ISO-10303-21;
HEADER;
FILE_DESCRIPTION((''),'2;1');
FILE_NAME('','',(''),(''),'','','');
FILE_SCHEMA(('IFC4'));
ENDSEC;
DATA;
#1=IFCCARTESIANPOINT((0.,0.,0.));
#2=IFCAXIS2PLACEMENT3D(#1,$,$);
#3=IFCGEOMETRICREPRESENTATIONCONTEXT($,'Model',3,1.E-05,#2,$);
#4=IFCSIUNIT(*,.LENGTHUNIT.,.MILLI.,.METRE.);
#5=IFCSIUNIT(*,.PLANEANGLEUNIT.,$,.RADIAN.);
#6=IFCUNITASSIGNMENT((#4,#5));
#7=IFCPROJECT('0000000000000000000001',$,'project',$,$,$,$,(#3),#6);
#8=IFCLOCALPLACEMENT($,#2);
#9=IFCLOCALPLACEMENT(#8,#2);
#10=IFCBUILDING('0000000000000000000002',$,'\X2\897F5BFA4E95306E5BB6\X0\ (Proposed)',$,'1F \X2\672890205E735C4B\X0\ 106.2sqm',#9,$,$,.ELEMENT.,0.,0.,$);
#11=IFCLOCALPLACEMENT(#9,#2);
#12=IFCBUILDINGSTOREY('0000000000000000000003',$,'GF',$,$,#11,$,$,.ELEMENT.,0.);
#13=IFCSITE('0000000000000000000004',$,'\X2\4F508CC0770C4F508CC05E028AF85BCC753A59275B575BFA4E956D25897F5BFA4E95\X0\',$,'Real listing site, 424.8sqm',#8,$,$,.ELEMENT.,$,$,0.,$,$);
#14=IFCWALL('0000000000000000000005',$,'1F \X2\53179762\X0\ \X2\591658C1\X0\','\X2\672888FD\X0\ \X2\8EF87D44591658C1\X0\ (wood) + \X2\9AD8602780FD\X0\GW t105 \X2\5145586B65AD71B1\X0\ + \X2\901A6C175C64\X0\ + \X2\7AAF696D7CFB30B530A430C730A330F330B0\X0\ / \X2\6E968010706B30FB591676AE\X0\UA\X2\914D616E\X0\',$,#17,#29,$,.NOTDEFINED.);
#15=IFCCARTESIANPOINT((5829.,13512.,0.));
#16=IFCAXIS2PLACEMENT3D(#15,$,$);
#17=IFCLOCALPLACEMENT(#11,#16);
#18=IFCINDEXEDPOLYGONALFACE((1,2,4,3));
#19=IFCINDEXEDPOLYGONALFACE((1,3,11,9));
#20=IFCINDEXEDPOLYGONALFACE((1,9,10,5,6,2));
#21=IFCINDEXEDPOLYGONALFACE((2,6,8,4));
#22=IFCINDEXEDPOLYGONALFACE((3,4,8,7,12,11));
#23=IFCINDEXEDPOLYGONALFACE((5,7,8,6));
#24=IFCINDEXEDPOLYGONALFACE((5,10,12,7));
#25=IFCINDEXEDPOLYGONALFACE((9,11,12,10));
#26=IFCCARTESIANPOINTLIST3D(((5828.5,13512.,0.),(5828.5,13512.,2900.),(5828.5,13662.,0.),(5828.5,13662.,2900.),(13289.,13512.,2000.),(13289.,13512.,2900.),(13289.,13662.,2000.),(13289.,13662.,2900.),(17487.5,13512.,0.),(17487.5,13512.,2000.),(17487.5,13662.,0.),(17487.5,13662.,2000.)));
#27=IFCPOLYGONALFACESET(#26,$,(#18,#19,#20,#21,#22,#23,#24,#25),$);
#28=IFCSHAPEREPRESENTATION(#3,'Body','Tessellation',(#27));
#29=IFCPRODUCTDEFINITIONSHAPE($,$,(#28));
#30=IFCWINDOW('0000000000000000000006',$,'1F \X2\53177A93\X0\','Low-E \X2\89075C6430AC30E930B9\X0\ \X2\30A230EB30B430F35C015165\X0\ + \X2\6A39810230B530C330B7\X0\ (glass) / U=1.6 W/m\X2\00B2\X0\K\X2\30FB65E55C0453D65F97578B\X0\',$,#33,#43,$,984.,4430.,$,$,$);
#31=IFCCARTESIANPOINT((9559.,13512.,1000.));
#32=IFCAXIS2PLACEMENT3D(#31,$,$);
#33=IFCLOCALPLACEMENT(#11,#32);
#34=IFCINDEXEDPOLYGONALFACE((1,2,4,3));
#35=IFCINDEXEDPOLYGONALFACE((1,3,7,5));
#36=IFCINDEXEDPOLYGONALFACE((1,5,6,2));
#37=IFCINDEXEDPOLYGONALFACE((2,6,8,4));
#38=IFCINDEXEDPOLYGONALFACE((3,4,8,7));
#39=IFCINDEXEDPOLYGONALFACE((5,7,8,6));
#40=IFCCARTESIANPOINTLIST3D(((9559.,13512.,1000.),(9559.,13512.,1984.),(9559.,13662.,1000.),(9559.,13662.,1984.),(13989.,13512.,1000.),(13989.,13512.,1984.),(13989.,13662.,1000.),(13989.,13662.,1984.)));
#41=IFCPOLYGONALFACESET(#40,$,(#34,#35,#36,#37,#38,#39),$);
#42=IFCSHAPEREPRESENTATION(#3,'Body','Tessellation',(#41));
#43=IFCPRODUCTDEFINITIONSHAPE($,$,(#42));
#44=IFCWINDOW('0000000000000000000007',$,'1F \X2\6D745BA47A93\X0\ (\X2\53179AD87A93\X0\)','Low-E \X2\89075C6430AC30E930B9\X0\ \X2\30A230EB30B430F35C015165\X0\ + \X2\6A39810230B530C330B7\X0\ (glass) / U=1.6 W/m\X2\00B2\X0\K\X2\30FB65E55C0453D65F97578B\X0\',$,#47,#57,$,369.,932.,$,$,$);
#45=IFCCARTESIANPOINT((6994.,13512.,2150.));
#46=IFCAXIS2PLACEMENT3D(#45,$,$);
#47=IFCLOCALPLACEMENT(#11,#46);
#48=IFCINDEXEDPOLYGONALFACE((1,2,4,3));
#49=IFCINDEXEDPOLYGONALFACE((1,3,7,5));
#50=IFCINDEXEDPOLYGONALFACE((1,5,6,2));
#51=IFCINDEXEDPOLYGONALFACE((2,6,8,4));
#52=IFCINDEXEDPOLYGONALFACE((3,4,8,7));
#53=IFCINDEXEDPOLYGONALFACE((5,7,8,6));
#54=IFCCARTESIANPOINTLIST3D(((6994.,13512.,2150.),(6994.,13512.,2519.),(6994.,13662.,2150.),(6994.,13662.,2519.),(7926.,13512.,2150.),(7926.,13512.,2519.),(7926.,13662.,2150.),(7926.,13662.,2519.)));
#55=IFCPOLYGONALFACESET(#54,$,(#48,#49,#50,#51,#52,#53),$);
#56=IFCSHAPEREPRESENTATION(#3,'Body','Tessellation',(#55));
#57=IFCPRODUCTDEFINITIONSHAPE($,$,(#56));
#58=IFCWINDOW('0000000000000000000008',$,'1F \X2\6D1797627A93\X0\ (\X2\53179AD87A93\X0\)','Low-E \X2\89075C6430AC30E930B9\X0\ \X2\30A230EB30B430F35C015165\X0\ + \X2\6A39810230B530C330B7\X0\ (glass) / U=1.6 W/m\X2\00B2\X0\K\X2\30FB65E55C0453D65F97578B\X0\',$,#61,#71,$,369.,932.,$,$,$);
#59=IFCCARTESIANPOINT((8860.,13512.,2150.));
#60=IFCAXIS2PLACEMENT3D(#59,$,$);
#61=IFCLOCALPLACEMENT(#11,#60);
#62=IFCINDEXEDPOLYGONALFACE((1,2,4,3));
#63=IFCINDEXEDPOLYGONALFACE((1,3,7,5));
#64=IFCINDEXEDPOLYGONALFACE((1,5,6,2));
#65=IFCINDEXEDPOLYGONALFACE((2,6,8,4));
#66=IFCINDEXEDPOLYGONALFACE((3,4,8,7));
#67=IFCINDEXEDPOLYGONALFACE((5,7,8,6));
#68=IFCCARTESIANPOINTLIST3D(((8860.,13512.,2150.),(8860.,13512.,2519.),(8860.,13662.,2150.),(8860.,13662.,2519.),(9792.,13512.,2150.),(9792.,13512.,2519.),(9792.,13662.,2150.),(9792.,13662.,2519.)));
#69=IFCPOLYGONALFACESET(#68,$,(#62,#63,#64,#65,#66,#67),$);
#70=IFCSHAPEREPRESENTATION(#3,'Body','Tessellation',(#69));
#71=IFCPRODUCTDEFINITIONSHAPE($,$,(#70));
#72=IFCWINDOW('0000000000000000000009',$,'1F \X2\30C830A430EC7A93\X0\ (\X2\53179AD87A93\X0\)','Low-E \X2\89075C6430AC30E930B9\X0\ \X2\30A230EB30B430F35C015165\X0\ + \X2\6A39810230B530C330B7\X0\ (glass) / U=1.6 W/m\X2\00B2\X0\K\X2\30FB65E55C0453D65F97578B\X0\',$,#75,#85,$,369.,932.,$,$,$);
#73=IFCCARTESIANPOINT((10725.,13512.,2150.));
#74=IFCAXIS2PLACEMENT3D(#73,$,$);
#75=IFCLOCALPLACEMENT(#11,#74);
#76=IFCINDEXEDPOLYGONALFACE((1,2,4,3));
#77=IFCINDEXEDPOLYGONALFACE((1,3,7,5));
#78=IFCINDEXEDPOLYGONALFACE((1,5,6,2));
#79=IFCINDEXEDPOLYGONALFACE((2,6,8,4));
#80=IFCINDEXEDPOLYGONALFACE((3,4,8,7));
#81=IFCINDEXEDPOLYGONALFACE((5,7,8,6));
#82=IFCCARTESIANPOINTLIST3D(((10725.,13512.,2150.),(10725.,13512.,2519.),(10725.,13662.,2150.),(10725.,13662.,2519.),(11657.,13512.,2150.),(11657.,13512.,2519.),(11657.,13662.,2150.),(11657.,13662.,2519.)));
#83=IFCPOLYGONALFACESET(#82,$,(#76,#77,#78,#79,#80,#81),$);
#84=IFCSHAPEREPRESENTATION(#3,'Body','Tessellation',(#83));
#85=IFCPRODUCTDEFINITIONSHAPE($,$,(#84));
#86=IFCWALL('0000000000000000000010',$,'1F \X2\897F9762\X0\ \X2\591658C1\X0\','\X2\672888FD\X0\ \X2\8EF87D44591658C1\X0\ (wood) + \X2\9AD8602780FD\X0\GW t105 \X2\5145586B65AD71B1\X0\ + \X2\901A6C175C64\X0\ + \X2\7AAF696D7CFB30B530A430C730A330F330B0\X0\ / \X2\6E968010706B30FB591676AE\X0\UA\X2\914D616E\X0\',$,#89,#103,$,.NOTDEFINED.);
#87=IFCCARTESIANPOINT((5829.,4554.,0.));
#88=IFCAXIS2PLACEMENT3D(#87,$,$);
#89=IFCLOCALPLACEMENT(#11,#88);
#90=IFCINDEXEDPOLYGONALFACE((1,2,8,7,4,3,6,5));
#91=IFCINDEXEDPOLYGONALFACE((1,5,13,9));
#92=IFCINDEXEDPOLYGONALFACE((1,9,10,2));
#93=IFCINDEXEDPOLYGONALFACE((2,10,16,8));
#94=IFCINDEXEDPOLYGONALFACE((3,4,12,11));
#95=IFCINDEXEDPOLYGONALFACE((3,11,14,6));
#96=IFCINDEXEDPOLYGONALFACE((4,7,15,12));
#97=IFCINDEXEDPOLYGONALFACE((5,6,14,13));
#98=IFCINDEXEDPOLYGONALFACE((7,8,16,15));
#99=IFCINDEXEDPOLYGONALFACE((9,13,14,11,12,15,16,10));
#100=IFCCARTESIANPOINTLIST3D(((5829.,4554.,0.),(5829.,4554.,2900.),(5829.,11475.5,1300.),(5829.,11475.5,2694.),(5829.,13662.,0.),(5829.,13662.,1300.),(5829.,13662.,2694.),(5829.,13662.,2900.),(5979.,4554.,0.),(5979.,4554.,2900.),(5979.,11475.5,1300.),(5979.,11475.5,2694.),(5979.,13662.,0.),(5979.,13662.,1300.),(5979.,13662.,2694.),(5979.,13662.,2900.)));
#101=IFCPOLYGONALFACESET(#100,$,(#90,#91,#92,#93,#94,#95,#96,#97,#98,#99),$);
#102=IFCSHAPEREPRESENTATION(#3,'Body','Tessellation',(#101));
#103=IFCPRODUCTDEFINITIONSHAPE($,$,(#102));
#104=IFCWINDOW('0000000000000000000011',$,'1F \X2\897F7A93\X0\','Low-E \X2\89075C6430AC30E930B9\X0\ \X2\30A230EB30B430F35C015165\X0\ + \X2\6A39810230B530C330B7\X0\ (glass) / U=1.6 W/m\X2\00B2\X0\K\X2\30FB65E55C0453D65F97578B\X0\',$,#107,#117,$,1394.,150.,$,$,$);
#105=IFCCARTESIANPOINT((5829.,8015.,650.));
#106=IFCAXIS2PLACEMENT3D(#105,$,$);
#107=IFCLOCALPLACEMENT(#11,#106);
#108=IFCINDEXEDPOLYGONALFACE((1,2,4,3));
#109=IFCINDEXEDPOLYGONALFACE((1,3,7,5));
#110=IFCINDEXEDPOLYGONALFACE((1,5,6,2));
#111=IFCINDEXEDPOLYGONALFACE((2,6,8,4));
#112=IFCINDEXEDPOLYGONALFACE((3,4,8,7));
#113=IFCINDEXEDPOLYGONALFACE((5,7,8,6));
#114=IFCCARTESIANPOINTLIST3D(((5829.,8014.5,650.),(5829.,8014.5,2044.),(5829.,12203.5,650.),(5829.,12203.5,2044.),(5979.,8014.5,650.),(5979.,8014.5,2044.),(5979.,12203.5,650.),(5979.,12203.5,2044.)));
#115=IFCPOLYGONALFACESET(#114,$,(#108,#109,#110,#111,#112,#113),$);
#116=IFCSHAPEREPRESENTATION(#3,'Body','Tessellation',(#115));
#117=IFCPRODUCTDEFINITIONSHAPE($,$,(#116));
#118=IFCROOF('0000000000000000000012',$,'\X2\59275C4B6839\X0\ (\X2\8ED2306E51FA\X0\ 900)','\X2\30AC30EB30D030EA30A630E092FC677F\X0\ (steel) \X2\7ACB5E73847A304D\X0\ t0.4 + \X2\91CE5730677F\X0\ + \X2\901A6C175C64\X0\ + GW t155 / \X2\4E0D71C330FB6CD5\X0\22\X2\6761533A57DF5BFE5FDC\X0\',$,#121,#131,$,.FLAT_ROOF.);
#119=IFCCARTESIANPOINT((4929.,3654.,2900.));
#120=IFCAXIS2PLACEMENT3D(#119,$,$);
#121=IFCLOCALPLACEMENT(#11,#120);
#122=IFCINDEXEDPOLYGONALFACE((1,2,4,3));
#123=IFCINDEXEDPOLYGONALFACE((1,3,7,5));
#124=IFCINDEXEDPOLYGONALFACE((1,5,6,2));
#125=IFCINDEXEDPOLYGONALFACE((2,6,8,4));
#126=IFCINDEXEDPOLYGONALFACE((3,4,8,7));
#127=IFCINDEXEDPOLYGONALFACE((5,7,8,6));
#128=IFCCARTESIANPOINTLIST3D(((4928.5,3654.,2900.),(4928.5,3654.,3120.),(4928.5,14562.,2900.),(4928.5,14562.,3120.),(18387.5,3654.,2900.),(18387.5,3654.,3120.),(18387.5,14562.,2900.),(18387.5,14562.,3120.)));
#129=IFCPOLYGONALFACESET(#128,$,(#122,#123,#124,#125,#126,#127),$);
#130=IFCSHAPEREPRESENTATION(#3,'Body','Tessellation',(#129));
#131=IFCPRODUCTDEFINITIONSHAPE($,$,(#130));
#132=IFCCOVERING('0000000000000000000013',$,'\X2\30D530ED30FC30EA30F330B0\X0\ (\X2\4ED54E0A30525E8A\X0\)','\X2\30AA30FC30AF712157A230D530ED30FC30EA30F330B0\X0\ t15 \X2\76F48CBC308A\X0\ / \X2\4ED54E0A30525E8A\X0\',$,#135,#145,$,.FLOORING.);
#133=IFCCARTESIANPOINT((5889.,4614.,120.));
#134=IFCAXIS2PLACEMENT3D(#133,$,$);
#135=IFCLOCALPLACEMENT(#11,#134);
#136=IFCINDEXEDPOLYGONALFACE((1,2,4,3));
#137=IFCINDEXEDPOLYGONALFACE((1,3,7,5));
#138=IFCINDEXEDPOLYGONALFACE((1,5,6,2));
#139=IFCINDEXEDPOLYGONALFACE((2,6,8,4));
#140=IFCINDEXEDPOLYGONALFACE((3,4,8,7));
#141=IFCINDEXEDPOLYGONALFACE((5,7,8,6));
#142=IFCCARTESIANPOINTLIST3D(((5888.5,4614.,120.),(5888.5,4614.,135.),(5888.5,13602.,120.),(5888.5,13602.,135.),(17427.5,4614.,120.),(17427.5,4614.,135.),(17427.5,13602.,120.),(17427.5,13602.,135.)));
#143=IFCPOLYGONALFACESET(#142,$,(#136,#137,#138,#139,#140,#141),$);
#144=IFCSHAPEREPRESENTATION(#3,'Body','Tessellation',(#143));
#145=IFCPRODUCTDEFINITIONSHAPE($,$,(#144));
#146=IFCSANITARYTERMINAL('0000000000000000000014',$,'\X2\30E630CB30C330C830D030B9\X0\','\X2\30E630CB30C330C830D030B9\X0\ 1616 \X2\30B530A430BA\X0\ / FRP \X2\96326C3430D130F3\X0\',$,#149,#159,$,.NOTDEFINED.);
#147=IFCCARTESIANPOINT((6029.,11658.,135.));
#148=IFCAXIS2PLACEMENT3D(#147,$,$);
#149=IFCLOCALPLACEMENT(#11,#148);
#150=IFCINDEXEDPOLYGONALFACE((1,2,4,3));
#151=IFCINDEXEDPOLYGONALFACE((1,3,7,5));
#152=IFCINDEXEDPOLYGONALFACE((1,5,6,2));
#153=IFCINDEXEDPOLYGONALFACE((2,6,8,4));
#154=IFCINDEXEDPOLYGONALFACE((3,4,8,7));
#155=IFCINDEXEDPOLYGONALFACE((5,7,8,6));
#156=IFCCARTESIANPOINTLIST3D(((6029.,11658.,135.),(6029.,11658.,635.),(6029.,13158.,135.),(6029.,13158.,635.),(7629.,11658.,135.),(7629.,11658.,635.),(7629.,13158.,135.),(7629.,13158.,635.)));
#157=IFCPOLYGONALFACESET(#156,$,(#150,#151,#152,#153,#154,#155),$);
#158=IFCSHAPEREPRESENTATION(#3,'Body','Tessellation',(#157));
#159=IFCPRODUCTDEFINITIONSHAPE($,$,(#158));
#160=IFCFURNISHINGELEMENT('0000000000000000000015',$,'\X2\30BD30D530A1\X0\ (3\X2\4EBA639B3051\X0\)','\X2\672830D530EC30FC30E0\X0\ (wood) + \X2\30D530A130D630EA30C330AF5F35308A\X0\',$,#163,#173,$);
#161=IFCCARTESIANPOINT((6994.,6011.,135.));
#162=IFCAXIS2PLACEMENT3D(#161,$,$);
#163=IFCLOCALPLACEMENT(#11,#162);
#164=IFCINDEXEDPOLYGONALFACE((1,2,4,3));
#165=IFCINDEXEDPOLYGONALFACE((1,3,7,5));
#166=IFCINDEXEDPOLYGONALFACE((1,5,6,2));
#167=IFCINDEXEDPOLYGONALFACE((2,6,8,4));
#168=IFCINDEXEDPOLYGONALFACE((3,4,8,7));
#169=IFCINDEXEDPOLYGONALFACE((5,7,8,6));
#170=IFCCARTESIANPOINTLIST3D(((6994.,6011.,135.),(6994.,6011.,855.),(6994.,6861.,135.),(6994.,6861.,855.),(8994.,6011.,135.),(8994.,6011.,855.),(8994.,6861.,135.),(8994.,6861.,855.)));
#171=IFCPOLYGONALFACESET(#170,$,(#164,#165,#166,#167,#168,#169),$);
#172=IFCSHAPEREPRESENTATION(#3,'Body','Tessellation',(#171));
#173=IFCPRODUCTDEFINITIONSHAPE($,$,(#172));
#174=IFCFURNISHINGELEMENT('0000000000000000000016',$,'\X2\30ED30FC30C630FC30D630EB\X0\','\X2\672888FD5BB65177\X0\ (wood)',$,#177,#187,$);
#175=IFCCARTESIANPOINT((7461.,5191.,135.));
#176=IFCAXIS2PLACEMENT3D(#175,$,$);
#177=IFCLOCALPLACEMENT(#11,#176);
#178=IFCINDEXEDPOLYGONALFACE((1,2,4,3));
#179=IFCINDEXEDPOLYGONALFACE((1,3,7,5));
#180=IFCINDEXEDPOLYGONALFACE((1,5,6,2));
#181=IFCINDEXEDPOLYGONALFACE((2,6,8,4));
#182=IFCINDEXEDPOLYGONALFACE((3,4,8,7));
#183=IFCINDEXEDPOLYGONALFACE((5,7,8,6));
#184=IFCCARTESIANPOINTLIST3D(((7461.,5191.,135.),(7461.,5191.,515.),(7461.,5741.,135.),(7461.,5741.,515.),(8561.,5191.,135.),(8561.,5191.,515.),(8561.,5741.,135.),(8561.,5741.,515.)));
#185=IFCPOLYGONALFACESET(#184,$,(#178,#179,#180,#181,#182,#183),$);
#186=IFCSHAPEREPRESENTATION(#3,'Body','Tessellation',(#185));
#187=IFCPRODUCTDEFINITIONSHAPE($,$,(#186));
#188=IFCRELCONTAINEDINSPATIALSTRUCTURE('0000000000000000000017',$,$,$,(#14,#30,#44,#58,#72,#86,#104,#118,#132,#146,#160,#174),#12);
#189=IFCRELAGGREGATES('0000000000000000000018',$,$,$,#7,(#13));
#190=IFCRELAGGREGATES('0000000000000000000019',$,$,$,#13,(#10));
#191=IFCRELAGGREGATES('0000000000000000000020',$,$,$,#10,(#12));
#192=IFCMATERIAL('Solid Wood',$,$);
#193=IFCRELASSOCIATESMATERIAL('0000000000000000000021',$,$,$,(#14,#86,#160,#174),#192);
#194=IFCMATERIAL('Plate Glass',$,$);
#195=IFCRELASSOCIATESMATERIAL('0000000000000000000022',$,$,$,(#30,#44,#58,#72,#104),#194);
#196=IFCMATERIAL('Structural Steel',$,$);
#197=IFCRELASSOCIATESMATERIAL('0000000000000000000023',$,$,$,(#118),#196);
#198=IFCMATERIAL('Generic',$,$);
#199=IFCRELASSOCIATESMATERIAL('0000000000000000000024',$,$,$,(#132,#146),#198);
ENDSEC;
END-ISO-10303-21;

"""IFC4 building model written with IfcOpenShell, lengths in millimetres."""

from ifc_helpers import new_model, si_unit, frame, frame_2d, origin, place, context, project, spatial, rectangle, extrude, material, element, fill, save


model = new_model("IFC4")

# Units and contexts
model_context = context("Model", 3, precision=1e-05, world=origin())
ifc_project = project(units=[si_unit("LENGTHUNIT", "METRE", prefix="MILLI"), si_unit("PLANEANGLEUNIT", "RADIAN")], contexts=[model_context])

# Site, building, storey
site_placement = place(None, origin())
site = spatial("IfcSite", under=ifc_project, at=site_placement, Name="佐賀県佐賀市諸富町大字寺井津西寺井", ObjectType="Real listing site, 424.8sqm", CompositionType="ELEMENT", RefElevation=0.0)
building_placement = place(site_placement, origin())
building = spatial("IfcBuilding", under=site, at=building_placement, Name="西寺井の家 (Proposed)", ObjectType="1F 木造平屋 106.2sqm", CompositionType="ELEMENT", ElevationOfRefHeight=0.0, ElevationOfTerrain=0.0)
storey_placement = place(building_placement, origin())
storey = spatial("IfcBuildingStorey", under=building, at=storey_placement, Name="GF", CompositionType="ELEMENT", Elevation=0.0)

# Shared definitions
ifc_material_1 = material(Name="Solid Wood")

# Shared definitions
ifc_material_2 = material(Name="Plate Glass")

# Wall, openings, windows
wall_1_placement = place(storey_placement, frame((5829.0, 13512.0, 0.0)))
wall_1 = element("IfcWall", 1, at=wall_1_placement, inside=storey, material=ifc_material_1, Name="1F 北面 外壁", Description="木製 軸組外壁 (wood) + 高性能GW t105 充填断熱 + 通気層 + 窯業系サイディング / 準耐火・外皮UA配慮", PredefinedType="NOTDEFINED", context=model_context, shape_type="SweptSolid", body=[
    extrude(rectangle(XDim=11659.0, YDim=150.0, at=frame_2d((5829.0, 75.0))), frame((5829.0, 13512.0, 0.0)), (0.0, 0.0, 1.0), 2900.0),
])
opening_1_placement = place(storey_placement, frame((9559.0, 13512.0, 1000.0)))
opening_1 = element("IfcOpeningElement", 2, at=opening_1_placement, cuts=wall_1, PredefinedType="NOTDEFINED", context=model_context, shape_type="SweptSolid", body=[
    extrude(rectangle(XDim=4430.0, YDim=150.0, at=frame_2d((2215.0, 75.0))), frame((9559.0, 13512.0, 1000.0)), (0.0, 0.0, 1.0), 984.0),
])
opening_2_placement = place(storey_placement, frame((6994.0, 13512.0, 2150.0)))
opening_2 = element("IfcOpeningElement", 3, at=opening_2_placement, cuts=wall_1, PredefinedType="NOTDEFINED", context=model_context, shape_type="SweptSolid", body=[
    extrude(rectangle(XDim=932.0, YDim=150.0, at=frame_2d((466.0, 75.0))), frame((6994.0, 13512.0, 2150.0)), (0.0, 0.0, 1.0), 369.0),
])
opening_3_placement = place(storey_placement, frame((8860.0, 13512.0, 2150.0)))
opening_3 = element("IfcOpeningElement", 4, at=opening_3_placement, cuts=wall_1, PredefinedType="NOTDEFINED", context=model_context, shape_type="SweptSolid", body=[
    extrude(rectangle(XDim=932.0, YDim=150.0, at=frame_2d((466.0, 75.0))), frame((8860.0, 13512.0, 2150.0)), (0.0, 0.0, 1.0), 369.0),
])
opening_4_placement = place(storey_placement, frame((10725.0, 13512.0, 2150.0)))
opening_4 = element("IfcOpeningElement", 5, at=opening_4_placement, cuts=wall_1, PredefinedType="NOTDEFINED", context=model_context, shape_type="SweptSolid", body=[
    extrude(rectangle(XDim=932.0, YDim=150.0, at=frame_2d((466.0, 75.0))), frame((10725.0, 13512.0, 2150.0)), (0.0, 0.0, 1.0), 369.0),
])
window_1_placement = place(storey_placement, frame((9559.0, 13512.0, 1000.0)))
window_1 = element("IfcWindow", 6, at=window_1_placement, inside=storey, material=ifc_material_2, Name="1F 北窓", Description="Low-E 複層ガラス アルゴン封入 + 樹脂サッシ (glass) / U=1.6 W/m²K・日射取得型", OverallHeight=984.0, OverallWidth=4430.0, context=model_context, shape_type="SweptSolid", body=[
    extrude(rectangle(XDim=4430.0, YDim=150.0, at=frame_2d((2215.0, 75.0))), frame((9559.0, 13512.0, 1000.0)), (0.0, 0.0, 1.0), 984.0),
])
fill(opening_1, window_1)
window_2_placement = place(storey_placement, frame((6994.0, 13512.0, 2150.0)))
window_2 = element("IfcWindow", 7, at=window_2_placement, inside=storey, material=ifc_material_2, Name="1F 浴室窓 (北高窓)", Description="Low-E 複層ガラス アルゴン封入 + 樹脂サッシ (glass) / U=1.6 W/m²K・日射取得型", OverallHeight=369.0, OverallWidth=932.0, context=model_context, shape_type="SweptSolid", body=[
    extrude(rectangle(XDim=932.0, YDim=150.0, at=frame_2d((466.0, 75.0))), frame((6994.0, 13512.0, 2150.0)), (0.0, 0.0, 1.0), 369.0),
])
fill(opening_2, window_2)
window_3_placement = place(storey_placement, frame((8860.0, 13512.0, 2150.0)))
window_3 = element("IfcWindow", 8, at=window_3_placement, inside=storey, material=ifc_material_2, Name="1F 洗面窓 (北高窓)", Description="Low-E 複層ガラス アルゴン封入 + 樹脂サッシ (glass) / U=1.6 W/m²K・日射取得型", OverallHeight=369.0, OverallWidth=932.0, context=model_context, shape_type="SweptSolid", body=[
    extrude(rectangle(XDim=932.0, YDim=150.0, at=frame_2d((466.0, 75.0))), frame((8860.0, 13512.0, 2150.0)), (0.0, 0.0, 1.0), 369.0),
])
fill(opening_3, window_3)
window_4_placement = place(storey_placement, frame((10725.0, 13512.0, 2150.0)))
window_4 = element("IfcWindow", 9, at=window_4_placement, inside=storey, material=ifc_material_2, Name="1F トイレ窓 (北高窓)", Description="Low-E 複層ガラス アルゴン封入 + 樹脂サッシ (glass) / U=1.6 W/m²K・日射取得型", OverallHeight=369.0, OverallWidth=932.0, context=model_context, shape_type="SweptSolid", body=[
    extrude(rectangle(XDim=932.0, YDim=150.0, at=frame_2d((466.0, 75.0))), frame((10725.0, 13512.0, 2150.0)), (0.0, 0.0, 1.0), 369.0),
])
fill(opening_4, window_4)

# Wall, opening, window
wall_2_placement = place(storey_placement, frame((5829.0, 4554.0, 0.0)))
wall_2 = element("IfcWall", 10, at=wall_2_placement, inside=storey, material=ifc_material_1, Name="1F 西面 外壁", Description="木製 軸組外壁 (wood) + 高性能GW t105 充填断熱 + 通気層 + 窯業系サイディング / 準耐火・外皮UA配慮", PredefinedType="NOTDEFINED", context=model_context, shape_type="SweptSolid", body=[
    extrude(rectangle(XDim=150.0, YDim=9108.0, at=frame_2d((75.0, 4554.0))), frame((5829.0, 4554.0, 0.0)), (0.0, 0.0, 1.0), 2900.0),
])
opening_5_placement = place(storey_placement, frame((5829.0, 8015.0, 650.0)))
opening_5 = element("IfcOpeningElement", 11, at=opening_5_placement, cuts=wall_2, PredefinedType="NOTDEFINED", context=model_context, shape_type="SweptSolid", body=[
    extrude(rectangle(XDim=150.0, YDim=4189.0, at=frame_2d((75.0, 2094.0))), frame((5829.0, 8015.0, 650.0)), (0.0, 0.0, 1.0), 1394.0),
])
window_5_placement = place(storey_placement, frame((5829.0, 8015.0, 650.0)))
window_5 = element("IfcWindow", 12, at=window_5_placement, inside=storey, material=ifc_material_2, Name="1F 西窓", Description="Low-E 複層ガラス アルゴン封入 + 樹脂サッシ (glass) / U=1.6 W/m²K・日射取得型", OverallHeight=1394.0, OverallWidth=150.0, context=model_context, shape_type="SweptSolid", body=[
    extrude(rectangle(XDim=150.0, YDim=4189.0, at=frame_2d((75.0, 2094.0))), frame((5829.0, 8015.0, 650.0)), (0.0, 0.0, 1.0), 1394.0),
])
fill(opening_5, window_5)

# Roof
ifc_material_3 = material(Name="Structural Steel")
roof_placement = place(storey_placement, frame((4929.0, 3654.0, 2900.0)))
element("IfcRoof", 13, at=roof_placement, inside=storey, material=ifc_material_3, Name="大屋根 (軒の出 900)", Description="ガルバリウム鋼板 (steel) 立平葺き t0.4 + 野地板 + 通気層 + GW t155 / 不燃・法22条区域対応", PredefinedType="FLAT_ROOF", context=model_context, shape_type="SweptSolid", body=[
    extrude(rectangle(XDim=13459.0, YDim=10908.0, at=frame_2d((6729.0, 5454.0))), frame((4929.0, 3654.0, 2900.0)), (0.0, 0.0, 1.0), 220.0),
])

# Covering
ifc_material_4 = material(Name="Generic")
covering_placement = place(storey_placement, frame((5889.0, 4614.0, 120.0)))
element("IfcCovering", 14, at=covering_placement, inside=storey, material=ifc_material_4, Name="フローリング (仕上げ床)", Description="オーク無垢フローリング t15 直貼り / 仕上げ床", PredefinedType="FLOORING", context=model_context, shape_type="SweptSolid", body=[
    extrude(rectangle(XDim=11539.0, YDim=8988.0, at=frame_2d((5769.0, 4494.0))), frame((5889.0, 4614.0, 120.0)), (0.0, 0.0, 1.0), 15.0),
])

# Sanitary terminal
sanitary_terminal_placement = place(storey_placement, frame((6029.0, 11658.0, 135.0)))
element("IfcSanitaryTerminal", 15, at=sanitary_terminal_placement, inside=storey, material=ifc_material_4, Name="ユニットバス", Description="ユニットバス 1616 サイズ / FRP 防水パン", PredefinedType="NOTDEFINED", context=model_context, shape_type="SweptSolid", body=[
    extrude(rectangle(XDim=1600.0, YDim=1500.0, at=frame_2d((800.0, 750.0))), frame((6029.0, 11658.0, 135.0)), (0.0, 0.0, 1.0), 500.0),
])

# Furnishing elements
furnishing_1_placement = place(storey_placement, frame((6994.0, 6011.0, 135.0)))
element("IfcFurnishingElement", 16, at=furnishing_1_placement, inside=storey, material=ifc_material_1, Name="ソファ (3人掛け)", Description="木フレーム (wood) + ファブリック張り", context=model_context, shape_type="SweptSolid", body=[
    extrude(rectangle(XDim=2000.0, YDim=850.0, at=frame_2d((1000.0, 425.0))), frame((6994.0, 6011.0, 135.0)), (0.0, 0.0, 1.0), 720.0),
])
furnishing_2_placement = place(storey_placement, frame((7461.0, 5191.0, 135.0)))
element("IfcFurnishingElement", 17, at=furnishing_2_placement, inside=storey, material=ifc_material_1, Name="ローテーブル", Description="木製家具 (wood)", context=model_context, shape_type="SweptSolid", body=[
    extrude(rectangle(XDim=1100.0, YDim=550.0, at=frame_2d((550.0, 275.0))), frame((7461.0, 5191.0, 135.0)), (0.0, 0.0, 1.0), 380.0),
])

save(model, "model.ifc")
